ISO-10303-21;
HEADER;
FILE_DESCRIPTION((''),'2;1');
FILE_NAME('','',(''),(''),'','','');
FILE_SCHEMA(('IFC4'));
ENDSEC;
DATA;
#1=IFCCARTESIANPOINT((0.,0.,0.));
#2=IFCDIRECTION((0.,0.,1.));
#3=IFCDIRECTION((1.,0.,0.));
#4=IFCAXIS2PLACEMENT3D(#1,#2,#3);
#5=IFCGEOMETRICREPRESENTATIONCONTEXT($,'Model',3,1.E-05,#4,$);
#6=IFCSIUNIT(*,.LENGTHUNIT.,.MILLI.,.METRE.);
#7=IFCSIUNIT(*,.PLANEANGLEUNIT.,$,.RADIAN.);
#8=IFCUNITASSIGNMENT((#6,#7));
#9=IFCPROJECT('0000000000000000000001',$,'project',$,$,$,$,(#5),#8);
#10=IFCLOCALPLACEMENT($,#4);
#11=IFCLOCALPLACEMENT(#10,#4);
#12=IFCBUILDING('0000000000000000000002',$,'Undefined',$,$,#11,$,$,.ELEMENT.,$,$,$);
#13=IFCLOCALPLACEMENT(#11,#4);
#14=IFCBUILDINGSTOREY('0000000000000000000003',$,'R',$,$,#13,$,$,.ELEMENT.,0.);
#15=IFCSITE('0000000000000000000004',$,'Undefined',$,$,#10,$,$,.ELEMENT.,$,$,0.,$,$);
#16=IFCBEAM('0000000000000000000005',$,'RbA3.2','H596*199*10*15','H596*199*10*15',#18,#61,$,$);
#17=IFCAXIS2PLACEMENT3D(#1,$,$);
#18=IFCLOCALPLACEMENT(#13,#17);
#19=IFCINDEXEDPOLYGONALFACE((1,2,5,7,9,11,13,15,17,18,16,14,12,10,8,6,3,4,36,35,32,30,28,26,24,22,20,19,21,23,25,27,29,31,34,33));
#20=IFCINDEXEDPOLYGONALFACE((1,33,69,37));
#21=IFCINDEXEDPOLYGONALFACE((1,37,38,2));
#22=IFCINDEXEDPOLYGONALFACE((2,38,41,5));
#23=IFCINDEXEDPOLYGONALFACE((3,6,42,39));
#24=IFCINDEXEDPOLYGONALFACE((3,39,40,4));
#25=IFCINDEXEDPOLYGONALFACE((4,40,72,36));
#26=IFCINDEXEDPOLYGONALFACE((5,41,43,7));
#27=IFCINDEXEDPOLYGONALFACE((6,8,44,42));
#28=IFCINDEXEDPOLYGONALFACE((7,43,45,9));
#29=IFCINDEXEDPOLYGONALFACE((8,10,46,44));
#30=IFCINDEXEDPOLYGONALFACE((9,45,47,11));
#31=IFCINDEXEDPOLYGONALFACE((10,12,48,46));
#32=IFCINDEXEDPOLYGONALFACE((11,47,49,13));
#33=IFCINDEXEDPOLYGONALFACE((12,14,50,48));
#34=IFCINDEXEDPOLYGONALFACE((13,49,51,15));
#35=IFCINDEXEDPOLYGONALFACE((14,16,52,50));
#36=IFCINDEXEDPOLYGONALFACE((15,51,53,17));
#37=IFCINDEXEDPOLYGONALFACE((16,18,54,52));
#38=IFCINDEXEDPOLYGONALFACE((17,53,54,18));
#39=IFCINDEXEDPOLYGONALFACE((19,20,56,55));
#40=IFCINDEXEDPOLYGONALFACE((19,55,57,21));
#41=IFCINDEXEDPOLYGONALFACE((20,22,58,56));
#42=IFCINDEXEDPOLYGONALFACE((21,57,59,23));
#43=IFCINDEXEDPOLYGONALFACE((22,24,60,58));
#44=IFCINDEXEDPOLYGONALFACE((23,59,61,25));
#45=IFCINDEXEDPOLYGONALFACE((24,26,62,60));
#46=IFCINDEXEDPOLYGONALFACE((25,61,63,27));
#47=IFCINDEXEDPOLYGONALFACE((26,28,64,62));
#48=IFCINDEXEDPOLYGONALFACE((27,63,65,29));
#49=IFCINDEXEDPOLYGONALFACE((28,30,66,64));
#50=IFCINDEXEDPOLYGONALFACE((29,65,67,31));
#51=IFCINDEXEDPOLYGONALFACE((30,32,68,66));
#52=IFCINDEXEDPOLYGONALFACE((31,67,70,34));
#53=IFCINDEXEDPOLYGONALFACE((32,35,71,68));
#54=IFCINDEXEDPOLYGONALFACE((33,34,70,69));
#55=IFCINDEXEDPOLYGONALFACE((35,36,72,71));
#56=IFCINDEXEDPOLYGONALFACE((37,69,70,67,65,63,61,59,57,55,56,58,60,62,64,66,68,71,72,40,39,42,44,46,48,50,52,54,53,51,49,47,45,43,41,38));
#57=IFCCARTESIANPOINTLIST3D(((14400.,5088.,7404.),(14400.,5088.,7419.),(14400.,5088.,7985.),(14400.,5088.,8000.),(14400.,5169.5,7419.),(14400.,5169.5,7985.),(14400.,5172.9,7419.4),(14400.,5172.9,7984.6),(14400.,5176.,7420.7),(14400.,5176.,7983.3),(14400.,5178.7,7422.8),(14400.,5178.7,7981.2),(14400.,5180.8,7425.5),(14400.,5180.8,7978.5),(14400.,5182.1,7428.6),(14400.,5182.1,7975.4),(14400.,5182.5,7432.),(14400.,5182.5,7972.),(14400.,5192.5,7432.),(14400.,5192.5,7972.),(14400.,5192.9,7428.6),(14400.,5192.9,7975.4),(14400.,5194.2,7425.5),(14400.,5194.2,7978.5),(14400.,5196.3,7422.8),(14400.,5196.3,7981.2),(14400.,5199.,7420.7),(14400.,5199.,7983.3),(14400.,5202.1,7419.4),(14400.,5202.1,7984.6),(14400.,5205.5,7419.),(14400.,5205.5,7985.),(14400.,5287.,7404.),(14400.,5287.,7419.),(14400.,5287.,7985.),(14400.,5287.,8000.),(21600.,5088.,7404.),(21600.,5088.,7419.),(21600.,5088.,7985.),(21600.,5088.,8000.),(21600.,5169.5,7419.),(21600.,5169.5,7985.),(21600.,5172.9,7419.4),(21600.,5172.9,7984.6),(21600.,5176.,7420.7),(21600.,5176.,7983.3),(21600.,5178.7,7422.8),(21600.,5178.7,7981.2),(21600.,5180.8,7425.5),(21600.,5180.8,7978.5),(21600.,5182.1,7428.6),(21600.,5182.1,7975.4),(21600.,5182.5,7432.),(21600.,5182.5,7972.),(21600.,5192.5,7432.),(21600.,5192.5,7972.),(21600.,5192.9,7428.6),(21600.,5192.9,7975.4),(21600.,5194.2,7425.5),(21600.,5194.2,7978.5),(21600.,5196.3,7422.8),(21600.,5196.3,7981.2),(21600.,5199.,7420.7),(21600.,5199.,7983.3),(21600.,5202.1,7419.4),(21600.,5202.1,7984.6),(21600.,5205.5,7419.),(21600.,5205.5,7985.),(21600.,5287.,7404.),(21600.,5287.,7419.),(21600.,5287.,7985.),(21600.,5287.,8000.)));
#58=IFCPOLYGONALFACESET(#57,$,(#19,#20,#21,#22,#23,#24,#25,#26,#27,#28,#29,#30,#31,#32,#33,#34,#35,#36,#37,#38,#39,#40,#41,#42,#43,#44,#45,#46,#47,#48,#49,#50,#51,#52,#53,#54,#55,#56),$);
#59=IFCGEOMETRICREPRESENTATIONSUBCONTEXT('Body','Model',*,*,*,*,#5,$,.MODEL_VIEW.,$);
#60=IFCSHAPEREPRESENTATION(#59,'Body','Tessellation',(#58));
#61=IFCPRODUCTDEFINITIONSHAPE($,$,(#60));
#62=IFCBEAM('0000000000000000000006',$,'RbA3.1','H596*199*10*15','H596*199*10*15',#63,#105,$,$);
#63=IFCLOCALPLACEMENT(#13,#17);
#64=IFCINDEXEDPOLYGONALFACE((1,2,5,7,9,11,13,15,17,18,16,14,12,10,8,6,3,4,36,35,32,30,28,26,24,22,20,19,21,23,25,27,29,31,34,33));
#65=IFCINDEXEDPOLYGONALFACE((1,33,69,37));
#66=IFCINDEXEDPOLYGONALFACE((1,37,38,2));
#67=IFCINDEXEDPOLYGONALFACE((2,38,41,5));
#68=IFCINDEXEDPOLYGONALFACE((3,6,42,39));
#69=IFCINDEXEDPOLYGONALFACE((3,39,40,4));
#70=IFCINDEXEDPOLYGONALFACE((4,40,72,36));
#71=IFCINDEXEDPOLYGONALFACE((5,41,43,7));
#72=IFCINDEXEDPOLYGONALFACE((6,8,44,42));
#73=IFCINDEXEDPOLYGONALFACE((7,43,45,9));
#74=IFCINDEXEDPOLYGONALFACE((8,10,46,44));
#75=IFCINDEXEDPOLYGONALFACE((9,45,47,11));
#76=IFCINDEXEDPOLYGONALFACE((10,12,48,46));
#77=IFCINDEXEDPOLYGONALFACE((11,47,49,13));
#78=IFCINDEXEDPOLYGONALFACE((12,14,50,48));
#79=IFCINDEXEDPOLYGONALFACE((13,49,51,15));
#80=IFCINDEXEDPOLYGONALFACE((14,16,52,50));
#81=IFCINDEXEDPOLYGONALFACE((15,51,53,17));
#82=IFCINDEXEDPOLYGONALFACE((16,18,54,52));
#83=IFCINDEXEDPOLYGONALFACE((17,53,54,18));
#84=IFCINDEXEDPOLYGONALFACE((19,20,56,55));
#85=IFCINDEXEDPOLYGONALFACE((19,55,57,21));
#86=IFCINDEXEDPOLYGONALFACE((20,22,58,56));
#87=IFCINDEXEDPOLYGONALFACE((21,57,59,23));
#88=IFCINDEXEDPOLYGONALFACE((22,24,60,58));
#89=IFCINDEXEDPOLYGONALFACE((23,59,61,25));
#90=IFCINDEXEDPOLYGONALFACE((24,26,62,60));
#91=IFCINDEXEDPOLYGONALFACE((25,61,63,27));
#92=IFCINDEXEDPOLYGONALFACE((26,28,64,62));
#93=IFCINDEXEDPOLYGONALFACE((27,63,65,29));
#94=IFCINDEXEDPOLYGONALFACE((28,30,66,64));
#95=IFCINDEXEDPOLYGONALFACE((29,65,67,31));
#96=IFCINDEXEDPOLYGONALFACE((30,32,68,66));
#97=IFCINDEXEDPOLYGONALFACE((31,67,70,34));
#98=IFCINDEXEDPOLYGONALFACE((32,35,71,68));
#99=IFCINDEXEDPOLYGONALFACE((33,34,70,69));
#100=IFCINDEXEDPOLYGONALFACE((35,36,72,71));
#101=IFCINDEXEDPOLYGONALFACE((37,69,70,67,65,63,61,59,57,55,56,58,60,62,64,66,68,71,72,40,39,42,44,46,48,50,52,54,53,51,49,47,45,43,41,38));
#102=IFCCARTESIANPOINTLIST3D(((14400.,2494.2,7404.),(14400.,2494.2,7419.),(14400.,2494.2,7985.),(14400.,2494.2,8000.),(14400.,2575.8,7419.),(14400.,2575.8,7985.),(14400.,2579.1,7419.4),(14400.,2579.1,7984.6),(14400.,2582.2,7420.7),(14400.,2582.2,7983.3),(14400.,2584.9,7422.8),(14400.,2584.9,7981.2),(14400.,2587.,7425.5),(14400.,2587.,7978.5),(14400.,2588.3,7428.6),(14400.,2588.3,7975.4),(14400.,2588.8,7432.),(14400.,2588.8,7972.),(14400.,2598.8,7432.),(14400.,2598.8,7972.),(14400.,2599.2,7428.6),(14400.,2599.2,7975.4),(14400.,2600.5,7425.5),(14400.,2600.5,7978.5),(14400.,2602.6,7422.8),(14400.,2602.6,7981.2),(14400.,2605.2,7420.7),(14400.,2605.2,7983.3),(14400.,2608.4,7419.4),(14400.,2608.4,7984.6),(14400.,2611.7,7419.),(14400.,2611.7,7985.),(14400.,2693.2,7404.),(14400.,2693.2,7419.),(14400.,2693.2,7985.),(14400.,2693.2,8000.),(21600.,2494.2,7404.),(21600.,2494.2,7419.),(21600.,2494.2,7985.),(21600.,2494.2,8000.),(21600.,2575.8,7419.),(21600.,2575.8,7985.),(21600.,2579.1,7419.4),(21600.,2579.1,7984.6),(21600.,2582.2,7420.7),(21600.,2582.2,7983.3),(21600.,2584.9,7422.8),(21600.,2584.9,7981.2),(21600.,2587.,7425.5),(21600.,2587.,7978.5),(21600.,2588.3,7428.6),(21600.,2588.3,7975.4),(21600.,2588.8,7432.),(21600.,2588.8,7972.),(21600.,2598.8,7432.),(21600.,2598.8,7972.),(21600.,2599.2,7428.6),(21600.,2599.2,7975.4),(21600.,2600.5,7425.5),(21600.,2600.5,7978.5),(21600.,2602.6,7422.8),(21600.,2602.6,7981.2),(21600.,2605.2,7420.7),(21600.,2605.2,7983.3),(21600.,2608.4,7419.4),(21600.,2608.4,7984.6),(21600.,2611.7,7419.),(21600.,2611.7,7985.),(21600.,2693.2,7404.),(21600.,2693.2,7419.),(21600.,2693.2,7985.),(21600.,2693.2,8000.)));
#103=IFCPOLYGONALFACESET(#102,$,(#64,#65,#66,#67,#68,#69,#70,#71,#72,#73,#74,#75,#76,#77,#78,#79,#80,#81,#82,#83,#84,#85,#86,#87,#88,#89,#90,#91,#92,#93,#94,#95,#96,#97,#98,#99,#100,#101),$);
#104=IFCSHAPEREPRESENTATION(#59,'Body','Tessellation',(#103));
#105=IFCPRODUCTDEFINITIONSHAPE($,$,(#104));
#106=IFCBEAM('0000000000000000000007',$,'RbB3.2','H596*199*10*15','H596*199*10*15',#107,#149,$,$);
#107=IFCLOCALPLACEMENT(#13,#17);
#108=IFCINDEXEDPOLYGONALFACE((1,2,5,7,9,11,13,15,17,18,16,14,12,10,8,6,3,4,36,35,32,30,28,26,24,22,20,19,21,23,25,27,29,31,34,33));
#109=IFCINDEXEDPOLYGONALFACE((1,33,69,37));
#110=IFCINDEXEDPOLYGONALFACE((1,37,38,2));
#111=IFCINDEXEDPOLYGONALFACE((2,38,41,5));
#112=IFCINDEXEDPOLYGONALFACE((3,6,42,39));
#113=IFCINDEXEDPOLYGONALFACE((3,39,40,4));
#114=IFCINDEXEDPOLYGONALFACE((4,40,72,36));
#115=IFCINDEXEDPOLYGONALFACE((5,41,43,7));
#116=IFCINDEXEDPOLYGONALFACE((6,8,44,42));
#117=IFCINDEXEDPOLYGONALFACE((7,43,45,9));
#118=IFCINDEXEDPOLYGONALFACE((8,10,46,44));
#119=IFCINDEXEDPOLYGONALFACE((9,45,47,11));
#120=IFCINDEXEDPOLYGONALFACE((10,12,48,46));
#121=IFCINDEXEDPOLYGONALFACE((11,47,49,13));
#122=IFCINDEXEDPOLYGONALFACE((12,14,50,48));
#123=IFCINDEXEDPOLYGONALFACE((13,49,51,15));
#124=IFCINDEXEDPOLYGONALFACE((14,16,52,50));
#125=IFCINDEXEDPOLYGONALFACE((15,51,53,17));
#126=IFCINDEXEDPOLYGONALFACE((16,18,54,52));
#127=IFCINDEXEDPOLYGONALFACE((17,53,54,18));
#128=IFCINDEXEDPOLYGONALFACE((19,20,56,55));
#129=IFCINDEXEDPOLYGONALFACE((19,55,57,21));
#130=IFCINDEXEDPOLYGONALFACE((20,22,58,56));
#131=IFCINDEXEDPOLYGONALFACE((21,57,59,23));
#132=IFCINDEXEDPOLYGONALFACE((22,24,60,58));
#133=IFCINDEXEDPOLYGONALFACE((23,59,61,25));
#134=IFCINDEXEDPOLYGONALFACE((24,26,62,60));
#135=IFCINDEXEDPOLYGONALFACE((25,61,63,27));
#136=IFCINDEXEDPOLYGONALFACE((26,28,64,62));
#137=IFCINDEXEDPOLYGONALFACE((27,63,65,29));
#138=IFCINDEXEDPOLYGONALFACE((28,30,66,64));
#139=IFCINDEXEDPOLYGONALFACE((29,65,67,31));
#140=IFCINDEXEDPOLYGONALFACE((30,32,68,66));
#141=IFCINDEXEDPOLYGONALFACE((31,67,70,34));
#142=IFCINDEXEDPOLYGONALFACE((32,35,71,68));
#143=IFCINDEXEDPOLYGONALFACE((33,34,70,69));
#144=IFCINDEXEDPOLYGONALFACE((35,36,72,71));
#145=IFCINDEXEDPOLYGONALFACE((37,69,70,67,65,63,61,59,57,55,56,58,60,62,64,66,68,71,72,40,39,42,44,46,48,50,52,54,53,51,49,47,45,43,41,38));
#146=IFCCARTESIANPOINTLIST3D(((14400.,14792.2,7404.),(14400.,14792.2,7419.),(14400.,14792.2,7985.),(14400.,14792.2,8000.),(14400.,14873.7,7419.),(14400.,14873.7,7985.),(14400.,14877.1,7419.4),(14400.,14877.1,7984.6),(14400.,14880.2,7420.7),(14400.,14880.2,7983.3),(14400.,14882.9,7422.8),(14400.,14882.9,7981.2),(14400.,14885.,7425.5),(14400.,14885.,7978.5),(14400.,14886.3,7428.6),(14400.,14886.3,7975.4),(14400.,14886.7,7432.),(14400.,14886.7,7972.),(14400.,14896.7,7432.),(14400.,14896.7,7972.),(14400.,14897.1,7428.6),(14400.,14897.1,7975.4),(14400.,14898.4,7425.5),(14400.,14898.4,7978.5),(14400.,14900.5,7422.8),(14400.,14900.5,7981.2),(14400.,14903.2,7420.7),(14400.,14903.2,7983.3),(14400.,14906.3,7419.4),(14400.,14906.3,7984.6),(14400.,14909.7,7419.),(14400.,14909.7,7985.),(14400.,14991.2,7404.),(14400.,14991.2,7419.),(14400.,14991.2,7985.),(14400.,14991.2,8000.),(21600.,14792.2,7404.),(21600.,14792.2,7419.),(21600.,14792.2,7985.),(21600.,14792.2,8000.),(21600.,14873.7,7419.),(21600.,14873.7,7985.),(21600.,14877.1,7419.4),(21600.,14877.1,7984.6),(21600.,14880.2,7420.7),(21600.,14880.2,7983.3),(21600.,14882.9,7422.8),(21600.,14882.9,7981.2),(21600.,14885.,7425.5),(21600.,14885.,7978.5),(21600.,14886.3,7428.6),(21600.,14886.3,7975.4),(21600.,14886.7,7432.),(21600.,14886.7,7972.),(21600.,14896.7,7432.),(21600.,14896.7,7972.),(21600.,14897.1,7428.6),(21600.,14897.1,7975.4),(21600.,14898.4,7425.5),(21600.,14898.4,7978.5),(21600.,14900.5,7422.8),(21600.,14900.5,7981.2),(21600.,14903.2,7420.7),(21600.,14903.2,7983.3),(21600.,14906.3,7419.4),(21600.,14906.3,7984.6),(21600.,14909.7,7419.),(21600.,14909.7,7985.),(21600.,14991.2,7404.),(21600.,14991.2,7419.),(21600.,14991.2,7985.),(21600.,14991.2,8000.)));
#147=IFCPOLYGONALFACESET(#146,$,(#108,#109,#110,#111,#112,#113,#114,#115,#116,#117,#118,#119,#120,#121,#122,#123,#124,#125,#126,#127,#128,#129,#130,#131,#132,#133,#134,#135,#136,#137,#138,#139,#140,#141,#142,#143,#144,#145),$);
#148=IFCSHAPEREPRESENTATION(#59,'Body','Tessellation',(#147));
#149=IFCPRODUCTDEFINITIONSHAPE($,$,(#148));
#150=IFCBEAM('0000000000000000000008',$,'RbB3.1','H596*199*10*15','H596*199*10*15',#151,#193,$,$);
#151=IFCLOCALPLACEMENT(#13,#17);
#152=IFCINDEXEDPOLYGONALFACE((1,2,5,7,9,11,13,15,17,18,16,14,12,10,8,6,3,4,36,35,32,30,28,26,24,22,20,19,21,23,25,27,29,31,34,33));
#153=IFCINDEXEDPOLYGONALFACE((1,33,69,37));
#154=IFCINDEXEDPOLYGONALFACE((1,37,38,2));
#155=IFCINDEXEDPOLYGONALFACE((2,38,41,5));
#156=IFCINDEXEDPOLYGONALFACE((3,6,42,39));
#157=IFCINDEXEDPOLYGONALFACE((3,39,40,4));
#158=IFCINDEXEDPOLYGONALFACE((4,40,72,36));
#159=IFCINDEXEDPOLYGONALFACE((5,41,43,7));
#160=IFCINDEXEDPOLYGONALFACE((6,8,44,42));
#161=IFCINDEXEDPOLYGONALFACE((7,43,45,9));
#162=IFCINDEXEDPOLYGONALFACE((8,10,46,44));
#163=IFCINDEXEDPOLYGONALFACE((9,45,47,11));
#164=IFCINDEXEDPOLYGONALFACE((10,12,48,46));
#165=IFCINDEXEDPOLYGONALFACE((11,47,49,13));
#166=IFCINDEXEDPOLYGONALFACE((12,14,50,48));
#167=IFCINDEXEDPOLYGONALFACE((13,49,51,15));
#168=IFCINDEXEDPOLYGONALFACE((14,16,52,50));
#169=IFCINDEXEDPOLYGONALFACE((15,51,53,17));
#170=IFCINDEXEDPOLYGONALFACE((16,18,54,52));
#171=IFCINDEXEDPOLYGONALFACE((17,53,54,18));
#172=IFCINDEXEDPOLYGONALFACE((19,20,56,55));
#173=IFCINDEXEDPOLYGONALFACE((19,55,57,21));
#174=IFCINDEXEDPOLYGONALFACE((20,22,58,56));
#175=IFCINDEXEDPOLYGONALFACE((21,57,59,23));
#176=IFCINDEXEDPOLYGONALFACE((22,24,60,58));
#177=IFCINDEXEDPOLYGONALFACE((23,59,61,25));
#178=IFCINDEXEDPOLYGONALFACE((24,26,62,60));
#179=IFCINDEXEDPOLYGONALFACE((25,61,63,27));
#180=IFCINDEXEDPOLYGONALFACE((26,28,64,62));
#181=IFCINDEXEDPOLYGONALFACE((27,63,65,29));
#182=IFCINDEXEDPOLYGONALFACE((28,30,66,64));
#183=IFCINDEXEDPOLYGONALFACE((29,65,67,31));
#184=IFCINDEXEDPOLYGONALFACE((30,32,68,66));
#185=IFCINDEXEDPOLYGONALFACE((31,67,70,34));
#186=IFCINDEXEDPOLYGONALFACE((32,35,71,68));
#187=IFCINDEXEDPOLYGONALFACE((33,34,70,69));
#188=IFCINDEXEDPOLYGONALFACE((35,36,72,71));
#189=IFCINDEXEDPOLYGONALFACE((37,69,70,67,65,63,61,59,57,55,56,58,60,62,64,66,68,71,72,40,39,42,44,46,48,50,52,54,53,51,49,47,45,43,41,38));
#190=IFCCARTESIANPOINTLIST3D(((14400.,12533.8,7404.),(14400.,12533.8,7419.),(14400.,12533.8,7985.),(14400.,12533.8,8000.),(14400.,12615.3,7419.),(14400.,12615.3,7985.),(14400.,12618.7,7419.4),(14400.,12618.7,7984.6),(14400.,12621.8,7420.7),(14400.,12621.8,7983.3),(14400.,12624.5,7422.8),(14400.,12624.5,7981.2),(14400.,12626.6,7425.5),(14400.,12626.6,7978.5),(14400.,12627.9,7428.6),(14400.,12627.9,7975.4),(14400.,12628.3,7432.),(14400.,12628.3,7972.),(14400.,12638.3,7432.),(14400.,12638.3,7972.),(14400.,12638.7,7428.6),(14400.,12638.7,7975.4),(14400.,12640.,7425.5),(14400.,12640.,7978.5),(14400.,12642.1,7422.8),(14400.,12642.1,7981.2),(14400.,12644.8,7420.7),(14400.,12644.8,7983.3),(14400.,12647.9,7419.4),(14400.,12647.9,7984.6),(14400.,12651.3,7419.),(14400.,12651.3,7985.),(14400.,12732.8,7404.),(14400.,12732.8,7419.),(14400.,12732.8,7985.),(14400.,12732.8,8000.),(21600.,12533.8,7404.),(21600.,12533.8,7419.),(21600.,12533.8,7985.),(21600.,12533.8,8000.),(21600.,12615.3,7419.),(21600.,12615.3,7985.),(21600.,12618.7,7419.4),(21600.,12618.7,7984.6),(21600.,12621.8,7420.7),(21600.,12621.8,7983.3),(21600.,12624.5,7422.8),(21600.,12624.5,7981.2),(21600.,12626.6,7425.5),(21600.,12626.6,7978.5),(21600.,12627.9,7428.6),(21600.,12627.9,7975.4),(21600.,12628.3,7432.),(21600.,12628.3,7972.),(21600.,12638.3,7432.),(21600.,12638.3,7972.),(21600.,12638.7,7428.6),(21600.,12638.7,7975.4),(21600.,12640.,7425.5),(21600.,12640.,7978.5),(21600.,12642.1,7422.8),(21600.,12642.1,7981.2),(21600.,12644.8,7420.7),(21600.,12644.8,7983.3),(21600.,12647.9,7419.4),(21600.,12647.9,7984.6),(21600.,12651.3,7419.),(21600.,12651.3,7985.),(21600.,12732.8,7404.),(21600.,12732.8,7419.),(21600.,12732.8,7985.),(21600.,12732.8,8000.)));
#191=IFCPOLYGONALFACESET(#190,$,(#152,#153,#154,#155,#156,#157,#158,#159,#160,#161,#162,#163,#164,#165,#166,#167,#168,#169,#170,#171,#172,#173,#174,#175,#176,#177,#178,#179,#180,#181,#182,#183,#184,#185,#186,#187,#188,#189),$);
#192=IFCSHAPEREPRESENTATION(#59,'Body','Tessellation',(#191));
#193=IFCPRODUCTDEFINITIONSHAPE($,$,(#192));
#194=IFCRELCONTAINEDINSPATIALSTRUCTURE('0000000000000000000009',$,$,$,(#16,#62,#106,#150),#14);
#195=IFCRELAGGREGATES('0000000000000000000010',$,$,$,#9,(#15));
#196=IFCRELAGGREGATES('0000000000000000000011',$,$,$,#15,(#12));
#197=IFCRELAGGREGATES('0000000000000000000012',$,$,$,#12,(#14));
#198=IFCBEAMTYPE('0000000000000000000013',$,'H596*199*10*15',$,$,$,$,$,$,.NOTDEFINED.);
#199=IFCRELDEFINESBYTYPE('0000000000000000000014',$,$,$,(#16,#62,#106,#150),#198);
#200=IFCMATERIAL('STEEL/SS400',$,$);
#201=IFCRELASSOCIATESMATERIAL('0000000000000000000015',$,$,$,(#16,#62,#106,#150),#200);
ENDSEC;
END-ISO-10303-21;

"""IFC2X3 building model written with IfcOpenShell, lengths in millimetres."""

from ifc_helpers import new_model, si_unit, frame, origin_with_axes, origin_2d_with_axis, place, context, subcontext, project, spatial, i_section, extrude, material, type_object, element, save


model = new_model("IFC2X3")

# Units and contexts
model_context = context("Model", 3, precision=1e-05, world=origin_with_axes())
body_context = subcontext(model_context, "Body", "Model", "MODEL_VIEW")
ifc_project = project(units=[si_unit("LENGTHUNIT", "METRE", prefix="MILLI"), si_unit("PLANEANGLEUNIT", "RADIAN")], contexts=[model_context])

# Site, building, storey
site_placement = place(None, origin_with_axes())
site = spatial("IfcSite", under=ifc_project, at=site_placement, Name="Undefined", CompositionType="ELEMENT", RefElevation=0.0)
building_placement = place(site_placement, origin_with_axes())
building = spatial("IfcBuilding", under=site, at=building_placement, Name="Undefined", CompositionType="ELEMENT")
storey_placement = place(building_placement, origin_with_axes())
storey = spatial("IfcBuildingStorey", under=building, at=storey_placement, Name="R", CompositionType="ELEMENT", Elevation=0.0)

# Beams
ifc_material_1 = material(Name="STEEL/SS400")
beam_type_1 = type_object("IfcBeamType", Name="H596*199*10*15", PredefinedType="NOTDEFINED")
for number, where, z_axis, x_axis, name in (
    (1, (14400.0, 5187.5, 7702.0), (0.0, 0.0, 1.0), (1.0, 0.0, 0.0), "RbA3.2"),
    (2, (14400.0, 2593.8, 7702.0), (0.0, 0.0, 1.0), (1.0, 0.0, 0.0), "RbA3.1"),
    (3, (14400.0, 14891.7, 7702.0), (0.0, 0.0, 1.0), (1.0, 0.0, 0.0), "RbB3.2"),
    (4, (14400.0, 12633.3, 7702.0), (0.0, 0.0, 1.0), (1.0, 0.0, 0.0), "RbB3.1"),
):
    element("IfcBeam", number, at=place(storey_placement, frame(where, z_axis=z_axis, x_axis=x_axis)), inside=storey, type_object=beam_type_1, material=ifc_material_1, Name=name, Description="H596*199*10*15", ObjectType="H596*199*10*15", context=body_context, shape_type="SweptSolid", body=[
        extrude(i_section(OverallWidth=199.0, OverallDepth=596.0, WebThickness=10.0, FlangeThickness=15.0, FilletRadius=13.0, at=origin_2d_with_axis()), frame((7200.0, 0.0, 0.0), z_axis=(-1.0, 0.0, 0.0), x_axis=(0.0, -1.0, 0.0)), (0.0, 0.0, 1.0), 7200.0),
    ])

save(model, "model.ifc")
